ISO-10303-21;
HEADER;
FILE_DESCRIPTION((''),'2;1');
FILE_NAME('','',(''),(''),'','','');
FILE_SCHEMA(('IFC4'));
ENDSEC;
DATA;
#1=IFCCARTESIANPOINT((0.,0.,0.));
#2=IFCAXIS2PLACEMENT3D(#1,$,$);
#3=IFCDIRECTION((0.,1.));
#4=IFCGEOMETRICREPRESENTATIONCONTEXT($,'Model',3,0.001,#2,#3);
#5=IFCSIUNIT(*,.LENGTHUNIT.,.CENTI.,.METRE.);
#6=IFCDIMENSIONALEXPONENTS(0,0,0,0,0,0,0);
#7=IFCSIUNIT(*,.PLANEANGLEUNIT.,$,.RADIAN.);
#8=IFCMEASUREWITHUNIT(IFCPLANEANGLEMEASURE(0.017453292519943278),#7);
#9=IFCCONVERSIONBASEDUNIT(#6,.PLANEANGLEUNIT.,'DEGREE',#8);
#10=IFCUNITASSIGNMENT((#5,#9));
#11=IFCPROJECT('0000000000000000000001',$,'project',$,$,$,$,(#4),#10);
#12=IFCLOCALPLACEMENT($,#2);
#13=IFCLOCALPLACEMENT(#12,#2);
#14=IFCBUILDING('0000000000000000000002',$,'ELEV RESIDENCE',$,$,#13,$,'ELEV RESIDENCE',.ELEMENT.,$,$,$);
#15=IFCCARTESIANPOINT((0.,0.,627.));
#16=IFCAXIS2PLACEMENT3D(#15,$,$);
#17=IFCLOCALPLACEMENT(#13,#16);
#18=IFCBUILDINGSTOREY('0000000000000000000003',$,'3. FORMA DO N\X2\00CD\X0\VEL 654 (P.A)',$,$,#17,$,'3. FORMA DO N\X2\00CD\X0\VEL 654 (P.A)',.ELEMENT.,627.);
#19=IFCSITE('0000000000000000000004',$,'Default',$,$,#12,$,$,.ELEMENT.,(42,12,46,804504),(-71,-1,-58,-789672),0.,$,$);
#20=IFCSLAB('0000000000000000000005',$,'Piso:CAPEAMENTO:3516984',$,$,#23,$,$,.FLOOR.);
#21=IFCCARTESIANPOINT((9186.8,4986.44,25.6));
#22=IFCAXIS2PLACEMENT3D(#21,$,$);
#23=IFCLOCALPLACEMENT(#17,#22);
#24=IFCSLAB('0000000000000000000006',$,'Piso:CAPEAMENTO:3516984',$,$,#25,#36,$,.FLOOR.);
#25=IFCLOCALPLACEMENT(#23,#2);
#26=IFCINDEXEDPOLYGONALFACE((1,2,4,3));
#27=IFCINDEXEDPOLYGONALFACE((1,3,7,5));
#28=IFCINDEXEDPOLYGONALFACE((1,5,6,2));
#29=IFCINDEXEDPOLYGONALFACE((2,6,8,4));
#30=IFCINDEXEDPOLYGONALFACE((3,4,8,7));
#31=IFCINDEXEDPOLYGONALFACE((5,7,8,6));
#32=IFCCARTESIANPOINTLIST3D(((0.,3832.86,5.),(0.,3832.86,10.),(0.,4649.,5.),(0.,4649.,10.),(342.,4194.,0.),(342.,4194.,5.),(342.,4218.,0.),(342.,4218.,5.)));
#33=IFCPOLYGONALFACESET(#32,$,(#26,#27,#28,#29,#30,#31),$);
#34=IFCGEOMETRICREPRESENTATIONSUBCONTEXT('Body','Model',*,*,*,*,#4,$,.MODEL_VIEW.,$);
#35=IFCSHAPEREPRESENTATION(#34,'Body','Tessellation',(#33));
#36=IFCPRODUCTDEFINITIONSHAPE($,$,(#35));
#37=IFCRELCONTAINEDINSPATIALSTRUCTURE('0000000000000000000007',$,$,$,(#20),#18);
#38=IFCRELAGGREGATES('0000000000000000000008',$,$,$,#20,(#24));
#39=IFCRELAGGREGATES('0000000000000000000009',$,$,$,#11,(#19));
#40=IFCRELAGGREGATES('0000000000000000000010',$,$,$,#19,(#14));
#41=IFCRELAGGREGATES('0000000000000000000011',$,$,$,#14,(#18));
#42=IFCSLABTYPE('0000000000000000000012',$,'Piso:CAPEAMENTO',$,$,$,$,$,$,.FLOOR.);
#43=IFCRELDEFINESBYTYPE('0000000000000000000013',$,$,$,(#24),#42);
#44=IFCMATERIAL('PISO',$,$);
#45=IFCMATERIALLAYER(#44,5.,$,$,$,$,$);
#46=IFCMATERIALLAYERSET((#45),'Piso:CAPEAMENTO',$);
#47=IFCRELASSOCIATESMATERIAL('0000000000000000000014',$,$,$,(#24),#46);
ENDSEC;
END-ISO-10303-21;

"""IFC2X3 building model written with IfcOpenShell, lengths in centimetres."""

from ifc_helpers import new_model, entity, si_unit, converted_unit, direction, frame, frame_2d, origin, place, context, subcontext, project, spatial, polyline, rectangle, outline, extrude, material, layer, layer_set, type_object, element, aggregate, save


model = new_model("IFC2X3")

# Units and contexts
model_context = context("Model", 3, precision=0.001, world=origin(), true_north=direction((0.0, 1.0)))
body_context = subcontext(model_context, "Body", "Model", "MODEL_VIEW")
ifc_project = project(units=[si_unit("LENGTHUNIT", "METRE", prefix="CENTI"), converted_unit("PLANEANGLEUNIT", "DEGREE", entity("IfcPlaneAngleMeasure", 0.017453292519943278), si_unit("PLANEANGLEUNIT", "RADIAN"), dimensions=[0, 0, 0, 0, 0, 0, 0])], contexts=[model_context])

# Site, building, storey
site_placement = place(None, origin())
site = spatial("IfcSite", under=ifc_project, at=site_placement, Name="Default", CompositionType="ELEMENT", RefLatitude=(42, 12, 46, 804504), RefLongitude=(-71, -1, -58, -789672), RefElevation=0.0)
building_placement = place(site_placement, origin())
building = spatial("IfcBuilding", under=site, at=building_placement, Name="ELEV RESIDENCE", LongName="ELEV RESIDENCE", CompositionType="ELEMENT")
storey_placement = place(building_placement, frame((0.0, 0.0, 627.0)))
storey = spatial("IfcBuildingStorey", under=building, at=storey_placement, Name="3. FORMA DO NÍVEL 654 (P.A)", LongName="3. FORMA DO NÍVEL 654 (P.A)", CompositionType="ELEMENT", Elevation=627.0)

# Slabs, openings
slab_1_placement = place(storey_placement, frame((9186.8, 4986.44, 25.6)))
slab_1 = element("IfcSlab", 1, at=slab_1_placement, inside=storey, Name="Piso:CAPEAMENTO:3516984", PredefinedType="FLOOR")
ifc_material_1 = material(Name="PISO")
ifc_layer_1 = layer(ifc_material_1, 5.0)
ifc_layer_set_1 = layer_set([ifc_layer_1], Name="Piso:CAPEAMENTO")
slab_type_1 = type_object("IfcSlabType", Name="Piso:CAPEAMENTO", PredefinedType="FLOOR")
slab_2_placement = place(slab_1_placement, origin())
slab_2 = element("IfcSlab", 2, at=slab_2_placement, type_object=slab_type_1, material=ifc_layer_set_1, Name="Piso:CAPEAMENTO:3516984", PredefinedType="FLOOR", context=body_context, shape_type="SweptSolid", body=[
    extrude(outline(polyline([(-171.02, 408.07), (-171.02, -408.07), (171.02, -46.93), (171.02, -22.93), (-171.02, 408.07)])), frame((171.0, 4240.93, 7.5), z_axis=(0.014618, 0.0, 0.999893), x_axis=(0.999893, 0.0, -0.014618)), (0.014618, 0.0, -0.999893), 5.0),
])
opening_1_placement = place(slab_1_placement, origin())
element("IfcOpeningElement", 3, at=opening_1_placement, cuts=slab_2, ObjectType="Opening", context=body_context, shape_type="SweptSolid", body=[
    extrude(rectangle(XDim=24.0, YDim=24.0, at=frame_2d((3688.18, -1862.38), x_axis=(0.783366, -0.621561))), frame((374.5, 4433.5, 7.5), z_axis=(0.0, -0.0116, 0.999933), x_axis=(0.621561, -0.783313, -0.009087)), (0.009087, -0.00721, -0.999933), 5.0),
])
opening_2_placement = place(slab_1_placement, origin())
element("IfcOpeningElement", 4, at=opening_2_placement, cuts=slab_2, ObjectType="Opening", context=body_context, shape_type="SweptSolid", body=[
    extrude(rectangle(XDim=24.0, YDim=24.0, at=frame_2d((3135.09, -1423.53), x_axis=(0.783366, -0.621561))), frame((374.5, 4433.5, 7.5), z_axis=(0.0, -0.0116, 0.999933), x_axis=(0.621561, -0.783313, -0.009087)), (0.009087, -0.00721, -0.999933), 5.0),
])
opening_3_placement = place(slab_1_placement, origin())
element("IfcOpeningElement", 5, at=opening_3_placement, cuts=slab_2, ObjectType="Opening", context=body_context, shape_type="SweptSolid", body=[
    extrude(rectangle(XDim=24.0, YDim=24.0, at=frame_2d((2469.18, -895.16), x_axis=(0.783366, -0.621561))), frame((374.5, 4433.5, 7.5), z_axis=(0.0, -0.0116, 0.999933), x_axis=(0.621561, -0.783313, -0.009087)), (0.009087, -0.00721, -0.999933), 5.0),
])
opening_4_placement = place(slab_1_placement, origin())
element("IfcOpeningElement", 6, at=opening_4_placement, cuts=slab_2, ObjectType="Opening", context=body_context, shape_type="SweptSolid", body=[
    extrude(rectangle(XDim=24.0, YDim=24.0, at=frame_2d((1906.69, -448.85), x_axis=(0.783366, -0.621561))), frame((374.5, 4433.5, 7.5), z_axis=(0.0, -0.0116, 0.999933), x_axis=(0.621561, -0.783313, -0.009087)), (0.009087, -0.00721, -0.999933), 5.0),
])
opening_5_placement = place(slab_1_placement, origin())
element("IfcOpeningElement", 7, at=opening_5_placement, cuts=slab_2, ObjectType="Opening", context=body_context, shape_type="SweptSolid", body=[
    extrude(rectangle(XDim=24.0, YDim=24.0, at=frame_2d((1249.39, 72.68), x_axis=(0.783366, -0.621561))), frame((374.5, 4433.5, 7.5), z_axis=(0.0, -0.0116, 0.999933), x_axis=(0.621561, -0.783313, -0.009087)), (0.009087, -0.00721, -0.999933), 5.0),
])
opening_6_placement = place(slab_1_placement, origin())
element("IfcOpeningElement", 8, at=opening_6_placement, cuts=slab_2, ObjectType="Opening", context=body_context, shape_type="SweptSolid", body=[
    extrude(rectangle(XDim=24.0, YDim=24.0, at=frame_2d((696.3, 511.53), x_axis=(0.783366, -0.621561))), frame((374.5, 4433.5, 7.5), z_axis=(0.0, -0.0116, 0.999933), x_axis=(0.621561, -0.783313, -0.009087)), (0.009087, -0.00721, -0.999933), 5.0),
])
opening_7_placement = place(slab_1_placement, origin())
element("IfcOpeningElement", 9, at=opening_7_placement, cuts=slab_2, ObjectType="Opening", context=body_context, shape_type="SweptSolid", body=[
    extrude(rectangle(XDim=24.0, YDim=24.0, at=frame_2d((2604.27, -2092.53), x_axis=(0.783366, -0.621561))), frame((374.5, 4433.5, 7.5), z_axis=(0.0, -0.0116, 0.999933), x_axis=(0.621561, -0.783313, -0.009087)), (0.009087, -0.00721, -0.999933), 5.0),
])
opening_8_placement = place(slab_1_placement, origin())
element("IfcOpeningElement", 10, at=opening_8_placement, cuts=slab_2, ObjectType="Opening", context=body_context, shape_type="SweptSolid", body=[
    extrude(rectangle(XDim=24.0, YDim=24.0, at=frame_2d((1938.36, -1564.16), x_axis=(0.783366, -0.621561))), frame((374.5, 4433.5, 7.5), z_axis=(0.0, -0.0116, 0.999933), x_axis=(0.621561, -0.783313, -0.009087)), (0.009087, -0.00721, -0.999933), 5.0),
])
opening_9_placement = place(slab_1_placement, origin())
element("IfcOpeningElement", 11, at=opening_9_placement, cuts=slab_2, ObjectType="Opening", context=body_context, shape_type="SweptSolid", body=[
    extrude(rectangle(XDim=24.0, YDim=24.0, at=frame_2d((1375.87, -1117.85), x_axis=(0.783366, -0.621561))), frame((374.5, 4433.5, 7.5), z_axis=(0.0, -0.0116, 0.999933), x_axis=(0.621561, -0.783313, -0.009087)), (0.009087, -0.00721, -0.999933), 5.0),
])
opening_10_placement = place(slab_1_placement, origin())
element("IfcOpeningElement", 12, at=opening_10_placement, cuts=slab_2, ObjectType="Opening", context=body_context, shape_type="SweptSolid", body=[
    extrude(rectangle(XDim=24.0, YDim=24.0, at=frame_2d((718.58, -596.32), x_axis=(0.783366, -0.621561))), frame((374.5, 4433.5, 7.5), z_axis=(0.0, -0.0116, 0.999933), x_axis=(0.621561, -0.783313, -0.009087)), (0.009087, -0.00721, -0.999933), 5.0),
])
opening_11_placement = place(slab_1_placement, origin())
element("IfcOpeningElement", 13, at=opening_11_placement, cuts=slab_2, ObjectType="Opening", context=body_context, shape_type="SweptSolid", body=[
    extrude(rectangle(XDim=24.0, YDim=24.0, at=frame_2d((165.48, -157.47), x_axis=(0.783366, -0.621561))), frame((374.5, 4433.5, 7.5), z_axis=(0.0, -0.0116, 0.999933), x_axis=(0.621561, -0.783313, -0.009087)), (0.009087, -0.00721, -0.999933), 5.0),
])
opening_12_placement = place(slab_1_placement, origin())
element("IfcOpeningElement", 14, at=opening_12_placement, cuts=slab_2, ObjectType="Opening", context=body_context, shape_type="SweptSolid", body=[
    extrude(rectangle(XDim=24.0, YDim=24.0, at=frame_2d((3157.36, -2531.38), x_axis=(0.783366, -0.621561))), frame((374.5, 4433.5, 7.5), z_axis=(0.0, -0.0116, 0.999933), x_axis=(0.621561, -0.783313, -0.009087)), (0.009087, -0.00721, -0.999933), 5.0),
])
aggregate(slab_1, [slab_2])

save(model, "model.ifc")
